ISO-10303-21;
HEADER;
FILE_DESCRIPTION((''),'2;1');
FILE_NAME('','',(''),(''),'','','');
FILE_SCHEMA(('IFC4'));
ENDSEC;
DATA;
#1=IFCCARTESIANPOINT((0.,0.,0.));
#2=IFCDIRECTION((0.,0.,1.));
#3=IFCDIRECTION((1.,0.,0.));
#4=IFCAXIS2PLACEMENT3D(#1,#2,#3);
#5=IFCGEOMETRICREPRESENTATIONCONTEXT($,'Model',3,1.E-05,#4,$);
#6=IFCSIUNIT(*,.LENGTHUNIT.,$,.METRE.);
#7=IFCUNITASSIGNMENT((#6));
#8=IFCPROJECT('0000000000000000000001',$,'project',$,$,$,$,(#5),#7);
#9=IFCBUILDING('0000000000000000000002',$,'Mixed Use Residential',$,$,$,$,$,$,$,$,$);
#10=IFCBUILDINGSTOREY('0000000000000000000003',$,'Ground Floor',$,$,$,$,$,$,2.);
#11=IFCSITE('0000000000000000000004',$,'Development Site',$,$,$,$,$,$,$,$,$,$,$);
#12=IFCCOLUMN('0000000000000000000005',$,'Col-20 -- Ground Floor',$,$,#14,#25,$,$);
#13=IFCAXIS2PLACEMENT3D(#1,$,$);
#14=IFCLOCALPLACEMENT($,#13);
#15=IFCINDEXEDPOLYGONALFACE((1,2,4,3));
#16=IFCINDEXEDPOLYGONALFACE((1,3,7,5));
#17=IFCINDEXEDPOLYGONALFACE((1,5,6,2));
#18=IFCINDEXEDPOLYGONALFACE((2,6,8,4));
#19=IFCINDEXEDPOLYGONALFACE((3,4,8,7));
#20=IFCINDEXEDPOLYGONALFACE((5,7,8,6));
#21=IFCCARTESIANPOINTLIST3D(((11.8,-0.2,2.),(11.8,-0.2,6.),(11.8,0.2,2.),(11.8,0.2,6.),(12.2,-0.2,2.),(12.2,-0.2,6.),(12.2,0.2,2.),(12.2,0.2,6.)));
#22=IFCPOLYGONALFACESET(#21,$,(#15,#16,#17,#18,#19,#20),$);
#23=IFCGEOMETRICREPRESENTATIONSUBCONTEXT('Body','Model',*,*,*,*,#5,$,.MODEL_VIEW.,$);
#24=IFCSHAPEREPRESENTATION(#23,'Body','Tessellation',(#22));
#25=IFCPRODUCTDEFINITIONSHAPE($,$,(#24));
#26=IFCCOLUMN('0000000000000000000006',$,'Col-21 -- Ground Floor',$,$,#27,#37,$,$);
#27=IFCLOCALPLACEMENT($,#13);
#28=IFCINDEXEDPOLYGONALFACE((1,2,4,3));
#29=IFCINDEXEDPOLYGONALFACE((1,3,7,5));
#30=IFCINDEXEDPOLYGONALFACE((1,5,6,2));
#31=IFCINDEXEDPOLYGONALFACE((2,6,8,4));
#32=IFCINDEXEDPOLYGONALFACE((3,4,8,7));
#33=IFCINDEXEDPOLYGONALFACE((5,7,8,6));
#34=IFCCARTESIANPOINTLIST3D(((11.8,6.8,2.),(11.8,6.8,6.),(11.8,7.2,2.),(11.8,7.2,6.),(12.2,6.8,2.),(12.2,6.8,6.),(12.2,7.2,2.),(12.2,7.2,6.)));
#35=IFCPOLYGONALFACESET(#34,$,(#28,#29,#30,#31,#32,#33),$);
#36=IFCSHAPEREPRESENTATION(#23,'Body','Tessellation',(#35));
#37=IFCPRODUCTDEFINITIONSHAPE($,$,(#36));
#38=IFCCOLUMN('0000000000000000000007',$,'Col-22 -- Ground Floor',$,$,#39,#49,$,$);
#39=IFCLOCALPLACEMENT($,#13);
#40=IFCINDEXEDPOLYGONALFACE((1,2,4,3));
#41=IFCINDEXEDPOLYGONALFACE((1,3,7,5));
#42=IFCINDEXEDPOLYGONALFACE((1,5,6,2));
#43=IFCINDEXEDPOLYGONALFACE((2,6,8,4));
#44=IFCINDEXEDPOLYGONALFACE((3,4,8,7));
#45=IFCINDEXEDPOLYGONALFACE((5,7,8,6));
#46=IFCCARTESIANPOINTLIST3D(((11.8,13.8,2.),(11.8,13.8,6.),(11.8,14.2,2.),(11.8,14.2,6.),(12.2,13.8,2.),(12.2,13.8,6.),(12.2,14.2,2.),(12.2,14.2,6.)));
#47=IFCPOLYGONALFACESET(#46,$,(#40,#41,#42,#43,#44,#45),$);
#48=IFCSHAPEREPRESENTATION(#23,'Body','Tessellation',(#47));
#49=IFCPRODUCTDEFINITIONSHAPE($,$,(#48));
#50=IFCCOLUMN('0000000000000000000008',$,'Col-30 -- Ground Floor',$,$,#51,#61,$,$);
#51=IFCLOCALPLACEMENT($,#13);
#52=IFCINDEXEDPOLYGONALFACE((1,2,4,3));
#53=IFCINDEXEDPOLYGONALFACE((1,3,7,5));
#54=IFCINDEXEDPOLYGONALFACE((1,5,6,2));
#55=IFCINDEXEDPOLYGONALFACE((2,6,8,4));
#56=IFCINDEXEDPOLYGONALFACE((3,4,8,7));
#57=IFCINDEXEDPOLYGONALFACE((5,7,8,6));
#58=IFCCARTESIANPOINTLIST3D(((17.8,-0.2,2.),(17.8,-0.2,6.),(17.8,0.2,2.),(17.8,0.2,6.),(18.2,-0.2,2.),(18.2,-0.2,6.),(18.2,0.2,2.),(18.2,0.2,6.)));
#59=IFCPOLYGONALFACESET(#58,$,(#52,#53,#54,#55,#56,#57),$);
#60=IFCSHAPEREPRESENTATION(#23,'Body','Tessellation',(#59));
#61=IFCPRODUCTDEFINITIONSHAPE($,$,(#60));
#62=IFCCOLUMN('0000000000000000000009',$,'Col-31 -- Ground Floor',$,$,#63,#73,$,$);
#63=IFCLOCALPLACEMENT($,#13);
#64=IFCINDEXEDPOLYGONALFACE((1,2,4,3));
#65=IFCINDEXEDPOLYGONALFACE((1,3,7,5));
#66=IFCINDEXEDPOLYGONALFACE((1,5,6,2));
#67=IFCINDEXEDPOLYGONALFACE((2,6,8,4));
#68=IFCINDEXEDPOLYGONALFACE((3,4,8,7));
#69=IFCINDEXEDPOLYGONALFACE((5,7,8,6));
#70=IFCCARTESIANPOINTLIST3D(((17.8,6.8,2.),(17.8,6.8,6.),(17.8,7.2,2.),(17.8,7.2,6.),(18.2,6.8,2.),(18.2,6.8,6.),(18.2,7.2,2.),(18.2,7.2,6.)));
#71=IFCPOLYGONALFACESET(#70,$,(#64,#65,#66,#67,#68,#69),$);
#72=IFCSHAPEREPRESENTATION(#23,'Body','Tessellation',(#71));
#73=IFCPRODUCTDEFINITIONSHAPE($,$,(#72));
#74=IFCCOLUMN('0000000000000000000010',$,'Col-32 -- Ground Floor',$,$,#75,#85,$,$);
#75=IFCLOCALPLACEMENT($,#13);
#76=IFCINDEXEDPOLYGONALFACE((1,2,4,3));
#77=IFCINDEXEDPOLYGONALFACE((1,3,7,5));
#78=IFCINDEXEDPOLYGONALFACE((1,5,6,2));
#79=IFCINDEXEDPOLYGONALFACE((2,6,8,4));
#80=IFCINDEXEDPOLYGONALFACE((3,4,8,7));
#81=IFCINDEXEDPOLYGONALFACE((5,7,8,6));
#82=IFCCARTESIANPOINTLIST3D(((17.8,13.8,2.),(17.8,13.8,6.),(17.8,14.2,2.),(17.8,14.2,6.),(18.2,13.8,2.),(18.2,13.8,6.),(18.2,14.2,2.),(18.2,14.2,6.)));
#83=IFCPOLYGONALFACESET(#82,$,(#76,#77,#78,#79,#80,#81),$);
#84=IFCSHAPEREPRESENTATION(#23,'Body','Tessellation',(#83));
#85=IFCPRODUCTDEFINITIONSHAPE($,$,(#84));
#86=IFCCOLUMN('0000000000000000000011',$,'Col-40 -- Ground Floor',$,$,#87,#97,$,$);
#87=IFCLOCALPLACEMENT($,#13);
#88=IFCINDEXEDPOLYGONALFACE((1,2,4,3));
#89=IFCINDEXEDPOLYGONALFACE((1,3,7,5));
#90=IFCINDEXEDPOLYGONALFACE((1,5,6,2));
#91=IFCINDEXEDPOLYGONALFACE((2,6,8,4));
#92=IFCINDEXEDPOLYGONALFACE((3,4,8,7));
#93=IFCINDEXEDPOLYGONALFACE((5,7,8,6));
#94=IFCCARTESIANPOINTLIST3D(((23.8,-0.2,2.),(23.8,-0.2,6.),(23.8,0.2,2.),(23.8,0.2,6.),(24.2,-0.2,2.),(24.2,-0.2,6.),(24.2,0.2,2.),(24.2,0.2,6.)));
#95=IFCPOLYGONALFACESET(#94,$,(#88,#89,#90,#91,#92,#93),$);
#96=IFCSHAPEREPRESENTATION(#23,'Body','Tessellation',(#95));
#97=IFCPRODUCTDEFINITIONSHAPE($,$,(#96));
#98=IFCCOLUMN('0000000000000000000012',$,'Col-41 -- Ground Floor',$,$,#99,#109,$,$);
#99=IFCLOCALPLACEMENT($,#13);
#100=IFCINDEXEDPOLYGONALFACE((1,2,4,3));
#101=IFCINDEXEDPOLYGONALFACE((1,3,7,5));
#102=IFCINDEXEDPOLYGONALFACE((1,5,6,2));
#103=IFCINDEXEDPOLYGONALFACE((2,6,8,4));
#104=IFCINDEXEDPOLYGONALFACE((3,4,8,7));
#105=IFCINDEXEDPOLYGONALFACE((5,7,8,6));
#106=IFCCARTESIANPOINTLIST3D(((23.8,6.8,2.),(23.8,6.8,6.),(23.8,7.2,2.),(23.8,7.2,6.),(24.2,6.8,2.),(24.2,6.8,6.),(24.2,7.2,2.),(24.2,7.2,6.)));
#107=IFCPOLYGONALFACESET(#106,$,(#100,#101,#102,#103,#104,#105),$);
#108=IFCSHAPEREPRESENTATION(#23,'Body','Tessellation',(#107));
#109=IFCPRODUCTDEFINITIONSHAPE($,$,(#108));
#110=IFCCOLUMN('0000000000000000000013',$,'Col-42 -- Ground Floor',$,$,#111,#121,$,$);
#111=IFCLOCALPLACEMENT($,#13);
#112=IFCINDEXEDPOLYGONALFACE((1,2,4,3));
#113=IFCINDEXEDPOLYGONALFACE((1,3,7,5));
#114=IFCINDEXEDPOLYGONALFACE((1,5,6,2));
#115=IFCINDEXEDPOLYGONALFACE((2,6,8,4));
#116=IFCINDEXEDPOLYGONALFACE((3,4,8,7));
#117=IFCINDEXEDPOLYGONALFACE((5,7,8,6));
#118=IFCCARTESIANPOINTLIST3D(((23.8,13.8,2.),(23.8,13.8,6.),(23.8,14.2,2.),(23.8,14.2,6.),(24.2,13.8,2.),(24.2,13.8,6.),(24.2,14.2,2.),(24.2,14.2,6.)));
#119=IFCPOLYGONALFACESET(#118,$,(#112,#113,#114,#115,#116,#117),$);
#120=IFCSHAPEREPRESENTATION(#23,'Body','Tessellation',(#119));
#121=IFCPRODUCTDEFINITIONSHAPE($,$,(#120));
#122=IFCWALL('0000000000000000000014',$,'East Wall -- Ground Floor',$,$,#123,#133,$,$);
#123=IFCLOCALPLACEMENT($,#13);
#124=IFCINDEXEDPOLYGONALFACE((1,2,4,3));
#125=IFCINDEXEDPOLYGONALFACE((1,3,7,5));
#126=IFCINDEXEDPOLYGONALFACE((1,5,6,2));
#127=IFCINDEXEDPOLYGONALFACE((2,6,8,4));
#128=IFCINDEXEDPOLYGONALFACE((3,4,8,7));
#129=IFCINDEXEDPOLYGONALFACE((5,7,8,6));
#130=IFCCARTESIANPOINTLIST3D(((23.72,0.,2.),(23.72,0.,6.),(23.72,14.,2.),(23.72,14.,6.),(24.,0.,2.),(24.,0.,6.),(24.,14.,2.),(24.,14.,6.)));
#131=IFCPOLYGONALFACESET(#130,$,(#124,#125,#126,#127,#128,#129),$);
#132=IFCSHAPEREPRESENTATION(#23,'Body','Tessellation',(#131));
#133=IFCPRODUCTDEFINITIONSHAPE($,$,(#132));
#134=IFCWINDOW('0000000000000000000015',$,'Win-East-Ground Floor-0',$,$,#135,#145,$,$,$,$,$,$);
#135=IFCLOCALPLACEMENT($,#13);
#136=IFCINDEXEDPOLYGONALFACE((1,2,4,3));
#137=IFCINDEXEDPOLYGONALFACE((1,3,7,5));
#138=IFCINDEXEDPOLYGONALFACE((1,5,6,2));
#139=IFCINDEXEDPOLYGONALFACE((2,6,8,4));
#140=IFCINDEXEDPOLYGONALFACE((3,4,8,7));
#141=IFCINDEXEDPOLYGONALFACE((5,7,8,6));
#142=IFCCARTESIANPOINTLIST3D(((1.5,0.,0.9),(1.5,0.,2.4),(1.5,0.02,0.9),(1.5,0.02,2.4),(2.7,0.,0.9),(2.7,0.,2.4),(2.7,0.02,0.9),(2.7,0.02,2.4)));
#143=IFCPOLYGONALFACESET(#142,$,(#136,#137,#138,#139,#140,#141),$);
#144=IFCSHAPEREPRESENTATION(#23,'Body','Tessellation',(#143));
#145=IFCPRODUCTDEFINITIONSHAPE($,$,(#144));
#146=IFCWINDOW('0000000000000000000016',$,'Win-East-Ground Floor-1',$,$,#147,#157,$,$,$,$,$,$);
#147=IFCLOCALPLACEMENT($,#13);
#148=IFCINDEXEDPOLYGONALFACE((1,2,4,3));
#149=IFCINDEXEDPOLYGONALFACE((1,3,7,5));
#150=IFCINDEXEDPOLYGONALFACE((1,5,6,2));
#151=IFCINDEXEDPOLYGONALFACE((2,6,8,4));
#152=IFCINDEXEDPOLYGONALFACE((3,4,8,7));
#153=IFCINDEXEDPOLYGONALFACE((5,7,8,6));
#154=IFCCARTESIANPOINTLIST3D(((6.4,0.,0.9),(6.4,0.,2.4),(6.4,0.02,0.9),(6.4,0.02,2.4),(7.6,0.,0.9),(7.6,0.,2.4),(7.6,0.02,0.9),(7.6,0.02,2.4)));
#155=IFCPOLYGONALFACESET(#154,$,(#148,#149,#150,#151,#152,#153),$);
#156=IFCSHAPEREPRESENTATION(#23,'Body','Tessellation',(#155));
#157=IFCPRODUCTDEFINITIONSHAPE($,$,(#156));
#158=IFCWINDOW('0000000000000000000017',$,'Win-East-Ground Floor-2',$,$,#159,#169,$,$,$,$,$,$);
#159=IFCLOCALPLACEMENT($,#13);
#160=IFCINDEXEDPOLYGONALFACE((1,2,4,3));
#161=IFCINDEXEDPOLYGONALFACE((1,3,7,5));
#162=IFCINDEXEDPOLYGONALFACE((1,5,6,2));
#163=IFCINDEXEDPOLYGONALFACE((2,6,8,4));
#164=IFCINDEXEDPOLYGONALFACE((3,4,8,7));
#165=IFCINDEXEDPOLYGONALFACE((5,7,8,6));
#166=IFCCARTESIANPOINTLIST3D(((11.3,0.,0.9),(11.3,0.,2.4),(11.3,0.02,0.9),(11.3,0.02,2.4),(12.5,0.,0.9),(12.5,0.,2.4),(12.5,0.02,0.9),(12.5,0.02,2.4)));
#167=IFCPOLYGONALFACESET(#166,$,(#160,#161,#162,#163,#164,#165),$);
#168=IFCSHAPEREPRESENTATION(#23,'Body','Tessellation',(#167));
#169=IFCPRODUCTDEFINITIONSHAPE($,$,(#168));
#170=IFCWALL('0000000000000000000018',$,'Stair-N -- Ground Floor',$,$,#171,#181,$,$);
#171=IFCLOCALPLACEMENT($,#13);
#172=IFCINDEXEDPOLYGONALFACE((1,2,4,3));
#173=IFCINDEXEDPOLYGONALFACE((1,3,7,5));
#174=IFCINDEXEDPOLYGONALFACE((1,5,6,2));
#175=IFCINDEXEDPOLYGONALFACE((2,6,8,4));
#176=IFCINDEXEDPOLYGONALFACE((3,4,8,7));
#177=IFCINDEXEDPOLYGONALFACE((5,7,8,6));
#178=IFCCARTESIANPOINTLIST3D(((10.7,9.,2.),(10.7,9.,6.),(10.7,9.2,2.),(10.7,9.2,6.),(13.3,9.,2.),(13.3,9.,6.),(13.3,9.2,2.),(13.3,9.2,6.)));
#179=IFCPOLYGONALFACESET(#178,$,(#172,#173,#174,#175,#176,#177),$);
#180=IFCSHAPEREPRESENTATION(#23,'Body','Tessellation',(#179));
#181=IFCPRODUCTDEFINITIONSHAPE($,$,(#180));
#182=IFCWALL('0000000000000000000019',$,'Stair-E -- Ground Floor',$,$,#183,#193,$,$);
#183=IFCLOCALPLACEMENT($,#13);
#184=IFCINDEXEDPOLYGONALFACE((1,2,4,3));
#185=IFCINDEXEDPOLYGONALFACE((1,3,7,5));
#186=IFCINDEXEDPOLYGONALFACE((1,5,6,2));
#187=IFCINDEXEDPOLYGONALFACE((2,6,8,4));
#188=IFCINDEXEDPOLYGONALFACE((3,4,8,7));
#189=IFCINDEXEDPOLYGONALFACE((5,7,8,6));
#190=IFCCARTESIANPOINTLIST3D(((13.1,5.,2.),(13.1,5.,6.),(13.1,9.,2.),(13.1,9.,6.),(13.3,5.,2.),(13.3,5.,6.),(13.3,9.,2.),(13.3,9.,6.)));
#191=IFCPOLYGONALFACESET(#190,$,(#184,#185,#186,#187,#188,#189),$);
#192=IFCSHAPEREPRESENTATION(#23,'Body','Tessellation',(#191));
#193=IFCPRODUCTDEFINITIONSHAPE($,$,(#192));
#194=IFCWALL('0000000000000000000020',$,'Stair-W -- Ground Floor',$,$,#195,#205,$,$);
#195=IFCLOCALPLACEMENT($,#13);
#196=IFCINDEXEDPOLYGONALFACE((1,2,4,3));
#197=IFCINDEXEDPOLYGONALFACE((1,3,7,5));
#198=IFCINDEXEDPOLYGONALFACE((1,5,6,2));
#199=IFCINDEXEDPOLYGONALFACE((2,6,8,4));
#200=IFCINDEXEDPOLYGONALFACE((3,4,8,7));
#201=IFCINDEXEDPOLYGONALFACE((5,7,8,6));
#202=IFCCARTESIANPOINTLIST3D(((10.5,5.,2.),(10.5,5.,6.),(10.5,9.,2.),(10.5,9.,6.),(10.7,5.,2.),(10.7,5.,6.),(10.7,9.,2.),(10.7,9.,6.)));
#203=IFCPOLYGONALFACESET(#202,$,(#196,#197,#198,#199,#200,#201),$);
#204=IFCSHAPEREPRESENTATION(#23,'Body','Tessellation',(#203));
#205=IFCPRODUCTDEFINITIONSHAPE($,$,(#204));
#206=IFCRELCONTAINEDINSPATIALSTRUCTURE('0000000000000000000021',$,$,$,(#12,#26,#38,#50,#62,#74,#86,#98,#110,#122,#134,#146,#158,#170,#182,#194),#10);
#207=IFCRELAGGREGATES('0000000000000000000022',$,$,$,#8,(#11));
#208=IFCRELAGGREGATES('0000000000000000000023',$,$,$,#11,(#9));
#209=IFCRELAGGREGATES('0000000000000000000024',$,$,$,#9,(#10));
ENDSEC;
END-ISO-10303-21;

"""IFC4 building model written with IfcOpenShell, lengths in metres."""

from ifc_helpers import new_model, si_unit, frame, origin_with_axes, place, context, subcontext, project, spatial, indexed_curve, rectangle, outline, extrude, element, fill, save


model = new_model("IFC4")

# Units and contexts
model_context = context("Model", 3, precision=1e-05, world=origin_with_axes())
body_context = subcontext(model_context, "Body", "Model", "MODEL_VIEW")
ifc_project = project(units=[si_unit("LENGTHUNIT", "METRE")], contexts=[model_context])

# Site, building, storey
site = spatial("IfcSite", under=ifc_project, Name="Development Site")
building = spatial("IfcBuilding", under=site, Name="Mixed Use Residential")
storey = spatial("IfcBuildingStorey", under=building, Name="Ground Floor", Elevation=2.0)

# Columns
for number, where, z_axis, x_axis, name in (
    (1, (12.0, 0.0, 2.0), (0.0, 0.0, 1.0), (1.0, 0.0, 0.0), "Col-20 -- Ground Floor"),
    (2, (12.0, 7.0, 2.0), (0.0, 0.0, 1.0), (1.0, 0.0, 0.0), "Col-21 -- Ground Floor"),
    (3, (12.0, 14.0, 2.0), (0.0, 0.0, 1.0), (1.0, 0.0, 0.0), "Col-22 -- Ground Floor"),
    (4, (18.0, 0.0, 2.0), (0.0, 0.0, 1.0), (1.0, 0.0, 0.0), "Col-30 -- Ground Floor"),
    (5, (18.0, 7.0, 2.0), (0.0, 0.0, 1.0), (1.0, 0.0, 0.0), "Col-31 -- Ground Floor"),
    (6, (18.0, 14.0, 2.0), (0.0, 0.0, 1.0), (1.0, 0.0, 0.0), "Col-32 -- Ground Floor"),
    (7, (24.0, 0.0, 2.0), (0.0, 0.0, 1.0), (1.0, 0.0, 0.0), "Col-40 -- Ground Floor"),
    (8, (24.0, 7.0, 2.0), (0.0, 0.0, 1.0), (1.0, 0.0, 0.0), "Col-41 -- Ground Floor"),
    (9, (24.0, 14.0, 2.0), (0.0, 0.0, 1.0), (1.0, 0.0, 0.0), "Col-42 -- Ground Floor"),
):
    element("IfcColumn", number, at=place(None, frame(where, z_axis=z_axis, x_axis=x_axis)), inside=storey, Name=name, context=body_context, shape_type="SweptSolid", body=[
        extrude(rectangle(XDim=0.4, YDim=0.4), origin_with_axes(), (0.0, 0.0, 1.0), 4.0),
    ])

# Wall, openings, windows
wall_1_placement = place(None, frame((24.0, 0.0, 2.0), z_axis=(0.0, 0.0, 1.0), x_axis=(0.0, 1.0, 0.0)))
wall_1 = element("IfcWall", 10, at=wall_1_placement, inside=storey, Name="East Wall -- Ground Floor", context=body_context, shape_type="SweptSolid", body=[
    extrude(outline(indexed_curve([(0.0, 0.0), (0.0, 0.28), (14.0, 0.28), (14.0, 0.0), (0.0, 0.0)], self_intersect=False)), origin_with_axes(), (0.0, 0.0, 1.0), 4.0),
])
opening_1_placement = place(wall_1_placement, frame((0.0, 22.5, -1.1), z_axis=(0.0, 0.0, 1.0), x_axis=(0.0, -1.0, 0.0)))
opening_1 = element("IfcOpeningElement", 11, at=opening_1_placement, cuts=wall_1, context=body_context, shape_type="SweptSolid", body=[
    extrude(outline(indexed_curve([(0.0, 0.0), (0.0, 0.28), (1.2, 0.28), (1.2, 0.0), (0.0, 0.0)], self_intersect=False)), origin_with_axes(), (0.0, 0.0, 1.0), 1.5),
])
opening_2_placement = place(wall_1_placement, frame((0.0, 17.6, -1.1), z_axis=(0.0, 0.0, 1.0), x_axis=(0.0, -1.0, 0.0)))
opening_2 = element("IfcOpeningElement", 12, at=opening_2_placement, cuts=wall_1, context=body_context, shape_type="SweptSolid", body=[
    extrude(outline(indexed_curve([(0.0, 0.0), (0.0, 0.28), (1.2, 0.28), (1.2, 0.0), (0.0, 0.0)], self_intersect=False)), origin_with_axes(), (0.0, 0.0, 1.0), 1.5),
])
opening_3_placement = place(wall_1_placement, frame((0.0, 12.7, -1.1), z_axis=(0.0, 0.0, 1.0), x_axis=(0.0, -1.0, 0.0)))
opening_3 = element("IfcOpeningElement", 13, at=opening_3_placement, cuts=wall_1, context=body_context, shape_type="SweptSolid", body=[
    extrude(outline(indexed_curve([(0.0, 0.0), (0.0, 0.28), (1.2, 0.28), (1.2, 0.0), (0.0, 0.0)], self_intersect=False)), origin_with_axes(), (0.0, 0.0, 1.0), 1.5),
])
window_1_placement = place(None, frame((1.5, 0.0, 0.9), z_axis=(0.0, 0.0, 1.0), x_axis=(1.0, 0.0, 0.0)))
window_1 = element("IfcWindow", 14, at=window_1_placement, inside=storey, Name="Win-East-Ground Floor-0", context=body_context, shape_type="SweptSolid", body=[
    extrude(outline(indexed_curve([(0.0, 0.0), (0.0, 0.02), (1.2, 0.02), (1.2, 0.0), (0.0, 0.0)], self_intersect=False)), origin_with_axes(), (0.0, 0.0, 1.0), 1.5),
])
fill(opening_1, window_1)
window_2_placement = place(None, frame((6.4, 0.0, 0.9), z_axis=(0.0, 0.0, 1.0), x_axis=(1.0, 0.0, 0.0)))
window_2 = element("IfcWindow", 15, at=window_2_placement, inside=storey, Name="Win-East-Ground Floor-1", context=body_context, shape_type="SweptSolid", body=[
    extrude(outline(indexed_curve([(0.0, 0.0), (0.0, 0.02), (1.2, 0.02), (1.2, 0.0), (0.0, 0.0)], self_intersect=False)), origin_with_axes(), (0.0, 0.0, 1.0), 1.5),
])
fill(opening_2, window_2)
window_3_placement = place(None, frame((11.3, 0.0, 0.9), z_axis=(0.0, 0.0, 1.0), x_axis=(1.0, 0.0, 0.0)))
window_3 = element("IfcWindow", 16, at=window_3_placement, inside=storey, Name="Win-East-Ground Floor-2", context=body_context, shape_type="SweptSolid", body=[
    extrude(outline(indexed_curve([(0.0, 0.0), (0.0, 0.02), (1.2, 0.02), (1.2, 0.0), (0.0, 0.0)], self_intersect=False)), origin_with_axes(), (0.0, 0.0, 1.0), 1.5),
])
fill(opening_3, window_3)

# Walls
wall_2_placement = place(None, frame((10.7, 9.0, 2.0), z_axis=(0.0, 0.0, 1.0), x_axis=(1.0, 0.0, 0.0)))
element("IfcWall", 17, at=wall_2_placement, inside=storey, Name="Stair-N -- Ground Floor", context=body_context, shape_type="SweptSolid", body=[
    extrude(outline(indexed_curve([(0.0, 0.0), (0.0, 0.2), (2.6, 0.2), (2.6, 0.0), (0.0, 0.0)], self_intersect=False)), origin_with_axes(), (0.0, 0.0, 1.0), 4.0),
])
for number, where, z_axis, x_axis, name in (
    (18, (13.3, 5.0, 2.0), (0.0, 0.0, 1.0), (0.0, 1.0, 0.0), "Stair-E -- Ground Floor"),
    (19, (10.7, 5.0, 2.0), (0.0, 0.0, 1.0), (0.0, 1.0, 0.0), "Stair-W -- Ground Floor"),
):
    element("IfcWall", number, at=place(None, frame(where, z_axis=z_axis, x_axis=x_axis)), inside=storey, Name=name, context=body_context, shape_type="SweptSolid", body=[
        extrude(outline(indexed_curve([(0.0, 0.0), (0.0, 0.2), (4.0, 0.2), (4.0, 0.0), (0.0, 0.0)], self_intersect=False)), origin_with_axes(), (0.0, 0.0, 1.0), 4.0),
    ])

save(model, "model.ifc")
